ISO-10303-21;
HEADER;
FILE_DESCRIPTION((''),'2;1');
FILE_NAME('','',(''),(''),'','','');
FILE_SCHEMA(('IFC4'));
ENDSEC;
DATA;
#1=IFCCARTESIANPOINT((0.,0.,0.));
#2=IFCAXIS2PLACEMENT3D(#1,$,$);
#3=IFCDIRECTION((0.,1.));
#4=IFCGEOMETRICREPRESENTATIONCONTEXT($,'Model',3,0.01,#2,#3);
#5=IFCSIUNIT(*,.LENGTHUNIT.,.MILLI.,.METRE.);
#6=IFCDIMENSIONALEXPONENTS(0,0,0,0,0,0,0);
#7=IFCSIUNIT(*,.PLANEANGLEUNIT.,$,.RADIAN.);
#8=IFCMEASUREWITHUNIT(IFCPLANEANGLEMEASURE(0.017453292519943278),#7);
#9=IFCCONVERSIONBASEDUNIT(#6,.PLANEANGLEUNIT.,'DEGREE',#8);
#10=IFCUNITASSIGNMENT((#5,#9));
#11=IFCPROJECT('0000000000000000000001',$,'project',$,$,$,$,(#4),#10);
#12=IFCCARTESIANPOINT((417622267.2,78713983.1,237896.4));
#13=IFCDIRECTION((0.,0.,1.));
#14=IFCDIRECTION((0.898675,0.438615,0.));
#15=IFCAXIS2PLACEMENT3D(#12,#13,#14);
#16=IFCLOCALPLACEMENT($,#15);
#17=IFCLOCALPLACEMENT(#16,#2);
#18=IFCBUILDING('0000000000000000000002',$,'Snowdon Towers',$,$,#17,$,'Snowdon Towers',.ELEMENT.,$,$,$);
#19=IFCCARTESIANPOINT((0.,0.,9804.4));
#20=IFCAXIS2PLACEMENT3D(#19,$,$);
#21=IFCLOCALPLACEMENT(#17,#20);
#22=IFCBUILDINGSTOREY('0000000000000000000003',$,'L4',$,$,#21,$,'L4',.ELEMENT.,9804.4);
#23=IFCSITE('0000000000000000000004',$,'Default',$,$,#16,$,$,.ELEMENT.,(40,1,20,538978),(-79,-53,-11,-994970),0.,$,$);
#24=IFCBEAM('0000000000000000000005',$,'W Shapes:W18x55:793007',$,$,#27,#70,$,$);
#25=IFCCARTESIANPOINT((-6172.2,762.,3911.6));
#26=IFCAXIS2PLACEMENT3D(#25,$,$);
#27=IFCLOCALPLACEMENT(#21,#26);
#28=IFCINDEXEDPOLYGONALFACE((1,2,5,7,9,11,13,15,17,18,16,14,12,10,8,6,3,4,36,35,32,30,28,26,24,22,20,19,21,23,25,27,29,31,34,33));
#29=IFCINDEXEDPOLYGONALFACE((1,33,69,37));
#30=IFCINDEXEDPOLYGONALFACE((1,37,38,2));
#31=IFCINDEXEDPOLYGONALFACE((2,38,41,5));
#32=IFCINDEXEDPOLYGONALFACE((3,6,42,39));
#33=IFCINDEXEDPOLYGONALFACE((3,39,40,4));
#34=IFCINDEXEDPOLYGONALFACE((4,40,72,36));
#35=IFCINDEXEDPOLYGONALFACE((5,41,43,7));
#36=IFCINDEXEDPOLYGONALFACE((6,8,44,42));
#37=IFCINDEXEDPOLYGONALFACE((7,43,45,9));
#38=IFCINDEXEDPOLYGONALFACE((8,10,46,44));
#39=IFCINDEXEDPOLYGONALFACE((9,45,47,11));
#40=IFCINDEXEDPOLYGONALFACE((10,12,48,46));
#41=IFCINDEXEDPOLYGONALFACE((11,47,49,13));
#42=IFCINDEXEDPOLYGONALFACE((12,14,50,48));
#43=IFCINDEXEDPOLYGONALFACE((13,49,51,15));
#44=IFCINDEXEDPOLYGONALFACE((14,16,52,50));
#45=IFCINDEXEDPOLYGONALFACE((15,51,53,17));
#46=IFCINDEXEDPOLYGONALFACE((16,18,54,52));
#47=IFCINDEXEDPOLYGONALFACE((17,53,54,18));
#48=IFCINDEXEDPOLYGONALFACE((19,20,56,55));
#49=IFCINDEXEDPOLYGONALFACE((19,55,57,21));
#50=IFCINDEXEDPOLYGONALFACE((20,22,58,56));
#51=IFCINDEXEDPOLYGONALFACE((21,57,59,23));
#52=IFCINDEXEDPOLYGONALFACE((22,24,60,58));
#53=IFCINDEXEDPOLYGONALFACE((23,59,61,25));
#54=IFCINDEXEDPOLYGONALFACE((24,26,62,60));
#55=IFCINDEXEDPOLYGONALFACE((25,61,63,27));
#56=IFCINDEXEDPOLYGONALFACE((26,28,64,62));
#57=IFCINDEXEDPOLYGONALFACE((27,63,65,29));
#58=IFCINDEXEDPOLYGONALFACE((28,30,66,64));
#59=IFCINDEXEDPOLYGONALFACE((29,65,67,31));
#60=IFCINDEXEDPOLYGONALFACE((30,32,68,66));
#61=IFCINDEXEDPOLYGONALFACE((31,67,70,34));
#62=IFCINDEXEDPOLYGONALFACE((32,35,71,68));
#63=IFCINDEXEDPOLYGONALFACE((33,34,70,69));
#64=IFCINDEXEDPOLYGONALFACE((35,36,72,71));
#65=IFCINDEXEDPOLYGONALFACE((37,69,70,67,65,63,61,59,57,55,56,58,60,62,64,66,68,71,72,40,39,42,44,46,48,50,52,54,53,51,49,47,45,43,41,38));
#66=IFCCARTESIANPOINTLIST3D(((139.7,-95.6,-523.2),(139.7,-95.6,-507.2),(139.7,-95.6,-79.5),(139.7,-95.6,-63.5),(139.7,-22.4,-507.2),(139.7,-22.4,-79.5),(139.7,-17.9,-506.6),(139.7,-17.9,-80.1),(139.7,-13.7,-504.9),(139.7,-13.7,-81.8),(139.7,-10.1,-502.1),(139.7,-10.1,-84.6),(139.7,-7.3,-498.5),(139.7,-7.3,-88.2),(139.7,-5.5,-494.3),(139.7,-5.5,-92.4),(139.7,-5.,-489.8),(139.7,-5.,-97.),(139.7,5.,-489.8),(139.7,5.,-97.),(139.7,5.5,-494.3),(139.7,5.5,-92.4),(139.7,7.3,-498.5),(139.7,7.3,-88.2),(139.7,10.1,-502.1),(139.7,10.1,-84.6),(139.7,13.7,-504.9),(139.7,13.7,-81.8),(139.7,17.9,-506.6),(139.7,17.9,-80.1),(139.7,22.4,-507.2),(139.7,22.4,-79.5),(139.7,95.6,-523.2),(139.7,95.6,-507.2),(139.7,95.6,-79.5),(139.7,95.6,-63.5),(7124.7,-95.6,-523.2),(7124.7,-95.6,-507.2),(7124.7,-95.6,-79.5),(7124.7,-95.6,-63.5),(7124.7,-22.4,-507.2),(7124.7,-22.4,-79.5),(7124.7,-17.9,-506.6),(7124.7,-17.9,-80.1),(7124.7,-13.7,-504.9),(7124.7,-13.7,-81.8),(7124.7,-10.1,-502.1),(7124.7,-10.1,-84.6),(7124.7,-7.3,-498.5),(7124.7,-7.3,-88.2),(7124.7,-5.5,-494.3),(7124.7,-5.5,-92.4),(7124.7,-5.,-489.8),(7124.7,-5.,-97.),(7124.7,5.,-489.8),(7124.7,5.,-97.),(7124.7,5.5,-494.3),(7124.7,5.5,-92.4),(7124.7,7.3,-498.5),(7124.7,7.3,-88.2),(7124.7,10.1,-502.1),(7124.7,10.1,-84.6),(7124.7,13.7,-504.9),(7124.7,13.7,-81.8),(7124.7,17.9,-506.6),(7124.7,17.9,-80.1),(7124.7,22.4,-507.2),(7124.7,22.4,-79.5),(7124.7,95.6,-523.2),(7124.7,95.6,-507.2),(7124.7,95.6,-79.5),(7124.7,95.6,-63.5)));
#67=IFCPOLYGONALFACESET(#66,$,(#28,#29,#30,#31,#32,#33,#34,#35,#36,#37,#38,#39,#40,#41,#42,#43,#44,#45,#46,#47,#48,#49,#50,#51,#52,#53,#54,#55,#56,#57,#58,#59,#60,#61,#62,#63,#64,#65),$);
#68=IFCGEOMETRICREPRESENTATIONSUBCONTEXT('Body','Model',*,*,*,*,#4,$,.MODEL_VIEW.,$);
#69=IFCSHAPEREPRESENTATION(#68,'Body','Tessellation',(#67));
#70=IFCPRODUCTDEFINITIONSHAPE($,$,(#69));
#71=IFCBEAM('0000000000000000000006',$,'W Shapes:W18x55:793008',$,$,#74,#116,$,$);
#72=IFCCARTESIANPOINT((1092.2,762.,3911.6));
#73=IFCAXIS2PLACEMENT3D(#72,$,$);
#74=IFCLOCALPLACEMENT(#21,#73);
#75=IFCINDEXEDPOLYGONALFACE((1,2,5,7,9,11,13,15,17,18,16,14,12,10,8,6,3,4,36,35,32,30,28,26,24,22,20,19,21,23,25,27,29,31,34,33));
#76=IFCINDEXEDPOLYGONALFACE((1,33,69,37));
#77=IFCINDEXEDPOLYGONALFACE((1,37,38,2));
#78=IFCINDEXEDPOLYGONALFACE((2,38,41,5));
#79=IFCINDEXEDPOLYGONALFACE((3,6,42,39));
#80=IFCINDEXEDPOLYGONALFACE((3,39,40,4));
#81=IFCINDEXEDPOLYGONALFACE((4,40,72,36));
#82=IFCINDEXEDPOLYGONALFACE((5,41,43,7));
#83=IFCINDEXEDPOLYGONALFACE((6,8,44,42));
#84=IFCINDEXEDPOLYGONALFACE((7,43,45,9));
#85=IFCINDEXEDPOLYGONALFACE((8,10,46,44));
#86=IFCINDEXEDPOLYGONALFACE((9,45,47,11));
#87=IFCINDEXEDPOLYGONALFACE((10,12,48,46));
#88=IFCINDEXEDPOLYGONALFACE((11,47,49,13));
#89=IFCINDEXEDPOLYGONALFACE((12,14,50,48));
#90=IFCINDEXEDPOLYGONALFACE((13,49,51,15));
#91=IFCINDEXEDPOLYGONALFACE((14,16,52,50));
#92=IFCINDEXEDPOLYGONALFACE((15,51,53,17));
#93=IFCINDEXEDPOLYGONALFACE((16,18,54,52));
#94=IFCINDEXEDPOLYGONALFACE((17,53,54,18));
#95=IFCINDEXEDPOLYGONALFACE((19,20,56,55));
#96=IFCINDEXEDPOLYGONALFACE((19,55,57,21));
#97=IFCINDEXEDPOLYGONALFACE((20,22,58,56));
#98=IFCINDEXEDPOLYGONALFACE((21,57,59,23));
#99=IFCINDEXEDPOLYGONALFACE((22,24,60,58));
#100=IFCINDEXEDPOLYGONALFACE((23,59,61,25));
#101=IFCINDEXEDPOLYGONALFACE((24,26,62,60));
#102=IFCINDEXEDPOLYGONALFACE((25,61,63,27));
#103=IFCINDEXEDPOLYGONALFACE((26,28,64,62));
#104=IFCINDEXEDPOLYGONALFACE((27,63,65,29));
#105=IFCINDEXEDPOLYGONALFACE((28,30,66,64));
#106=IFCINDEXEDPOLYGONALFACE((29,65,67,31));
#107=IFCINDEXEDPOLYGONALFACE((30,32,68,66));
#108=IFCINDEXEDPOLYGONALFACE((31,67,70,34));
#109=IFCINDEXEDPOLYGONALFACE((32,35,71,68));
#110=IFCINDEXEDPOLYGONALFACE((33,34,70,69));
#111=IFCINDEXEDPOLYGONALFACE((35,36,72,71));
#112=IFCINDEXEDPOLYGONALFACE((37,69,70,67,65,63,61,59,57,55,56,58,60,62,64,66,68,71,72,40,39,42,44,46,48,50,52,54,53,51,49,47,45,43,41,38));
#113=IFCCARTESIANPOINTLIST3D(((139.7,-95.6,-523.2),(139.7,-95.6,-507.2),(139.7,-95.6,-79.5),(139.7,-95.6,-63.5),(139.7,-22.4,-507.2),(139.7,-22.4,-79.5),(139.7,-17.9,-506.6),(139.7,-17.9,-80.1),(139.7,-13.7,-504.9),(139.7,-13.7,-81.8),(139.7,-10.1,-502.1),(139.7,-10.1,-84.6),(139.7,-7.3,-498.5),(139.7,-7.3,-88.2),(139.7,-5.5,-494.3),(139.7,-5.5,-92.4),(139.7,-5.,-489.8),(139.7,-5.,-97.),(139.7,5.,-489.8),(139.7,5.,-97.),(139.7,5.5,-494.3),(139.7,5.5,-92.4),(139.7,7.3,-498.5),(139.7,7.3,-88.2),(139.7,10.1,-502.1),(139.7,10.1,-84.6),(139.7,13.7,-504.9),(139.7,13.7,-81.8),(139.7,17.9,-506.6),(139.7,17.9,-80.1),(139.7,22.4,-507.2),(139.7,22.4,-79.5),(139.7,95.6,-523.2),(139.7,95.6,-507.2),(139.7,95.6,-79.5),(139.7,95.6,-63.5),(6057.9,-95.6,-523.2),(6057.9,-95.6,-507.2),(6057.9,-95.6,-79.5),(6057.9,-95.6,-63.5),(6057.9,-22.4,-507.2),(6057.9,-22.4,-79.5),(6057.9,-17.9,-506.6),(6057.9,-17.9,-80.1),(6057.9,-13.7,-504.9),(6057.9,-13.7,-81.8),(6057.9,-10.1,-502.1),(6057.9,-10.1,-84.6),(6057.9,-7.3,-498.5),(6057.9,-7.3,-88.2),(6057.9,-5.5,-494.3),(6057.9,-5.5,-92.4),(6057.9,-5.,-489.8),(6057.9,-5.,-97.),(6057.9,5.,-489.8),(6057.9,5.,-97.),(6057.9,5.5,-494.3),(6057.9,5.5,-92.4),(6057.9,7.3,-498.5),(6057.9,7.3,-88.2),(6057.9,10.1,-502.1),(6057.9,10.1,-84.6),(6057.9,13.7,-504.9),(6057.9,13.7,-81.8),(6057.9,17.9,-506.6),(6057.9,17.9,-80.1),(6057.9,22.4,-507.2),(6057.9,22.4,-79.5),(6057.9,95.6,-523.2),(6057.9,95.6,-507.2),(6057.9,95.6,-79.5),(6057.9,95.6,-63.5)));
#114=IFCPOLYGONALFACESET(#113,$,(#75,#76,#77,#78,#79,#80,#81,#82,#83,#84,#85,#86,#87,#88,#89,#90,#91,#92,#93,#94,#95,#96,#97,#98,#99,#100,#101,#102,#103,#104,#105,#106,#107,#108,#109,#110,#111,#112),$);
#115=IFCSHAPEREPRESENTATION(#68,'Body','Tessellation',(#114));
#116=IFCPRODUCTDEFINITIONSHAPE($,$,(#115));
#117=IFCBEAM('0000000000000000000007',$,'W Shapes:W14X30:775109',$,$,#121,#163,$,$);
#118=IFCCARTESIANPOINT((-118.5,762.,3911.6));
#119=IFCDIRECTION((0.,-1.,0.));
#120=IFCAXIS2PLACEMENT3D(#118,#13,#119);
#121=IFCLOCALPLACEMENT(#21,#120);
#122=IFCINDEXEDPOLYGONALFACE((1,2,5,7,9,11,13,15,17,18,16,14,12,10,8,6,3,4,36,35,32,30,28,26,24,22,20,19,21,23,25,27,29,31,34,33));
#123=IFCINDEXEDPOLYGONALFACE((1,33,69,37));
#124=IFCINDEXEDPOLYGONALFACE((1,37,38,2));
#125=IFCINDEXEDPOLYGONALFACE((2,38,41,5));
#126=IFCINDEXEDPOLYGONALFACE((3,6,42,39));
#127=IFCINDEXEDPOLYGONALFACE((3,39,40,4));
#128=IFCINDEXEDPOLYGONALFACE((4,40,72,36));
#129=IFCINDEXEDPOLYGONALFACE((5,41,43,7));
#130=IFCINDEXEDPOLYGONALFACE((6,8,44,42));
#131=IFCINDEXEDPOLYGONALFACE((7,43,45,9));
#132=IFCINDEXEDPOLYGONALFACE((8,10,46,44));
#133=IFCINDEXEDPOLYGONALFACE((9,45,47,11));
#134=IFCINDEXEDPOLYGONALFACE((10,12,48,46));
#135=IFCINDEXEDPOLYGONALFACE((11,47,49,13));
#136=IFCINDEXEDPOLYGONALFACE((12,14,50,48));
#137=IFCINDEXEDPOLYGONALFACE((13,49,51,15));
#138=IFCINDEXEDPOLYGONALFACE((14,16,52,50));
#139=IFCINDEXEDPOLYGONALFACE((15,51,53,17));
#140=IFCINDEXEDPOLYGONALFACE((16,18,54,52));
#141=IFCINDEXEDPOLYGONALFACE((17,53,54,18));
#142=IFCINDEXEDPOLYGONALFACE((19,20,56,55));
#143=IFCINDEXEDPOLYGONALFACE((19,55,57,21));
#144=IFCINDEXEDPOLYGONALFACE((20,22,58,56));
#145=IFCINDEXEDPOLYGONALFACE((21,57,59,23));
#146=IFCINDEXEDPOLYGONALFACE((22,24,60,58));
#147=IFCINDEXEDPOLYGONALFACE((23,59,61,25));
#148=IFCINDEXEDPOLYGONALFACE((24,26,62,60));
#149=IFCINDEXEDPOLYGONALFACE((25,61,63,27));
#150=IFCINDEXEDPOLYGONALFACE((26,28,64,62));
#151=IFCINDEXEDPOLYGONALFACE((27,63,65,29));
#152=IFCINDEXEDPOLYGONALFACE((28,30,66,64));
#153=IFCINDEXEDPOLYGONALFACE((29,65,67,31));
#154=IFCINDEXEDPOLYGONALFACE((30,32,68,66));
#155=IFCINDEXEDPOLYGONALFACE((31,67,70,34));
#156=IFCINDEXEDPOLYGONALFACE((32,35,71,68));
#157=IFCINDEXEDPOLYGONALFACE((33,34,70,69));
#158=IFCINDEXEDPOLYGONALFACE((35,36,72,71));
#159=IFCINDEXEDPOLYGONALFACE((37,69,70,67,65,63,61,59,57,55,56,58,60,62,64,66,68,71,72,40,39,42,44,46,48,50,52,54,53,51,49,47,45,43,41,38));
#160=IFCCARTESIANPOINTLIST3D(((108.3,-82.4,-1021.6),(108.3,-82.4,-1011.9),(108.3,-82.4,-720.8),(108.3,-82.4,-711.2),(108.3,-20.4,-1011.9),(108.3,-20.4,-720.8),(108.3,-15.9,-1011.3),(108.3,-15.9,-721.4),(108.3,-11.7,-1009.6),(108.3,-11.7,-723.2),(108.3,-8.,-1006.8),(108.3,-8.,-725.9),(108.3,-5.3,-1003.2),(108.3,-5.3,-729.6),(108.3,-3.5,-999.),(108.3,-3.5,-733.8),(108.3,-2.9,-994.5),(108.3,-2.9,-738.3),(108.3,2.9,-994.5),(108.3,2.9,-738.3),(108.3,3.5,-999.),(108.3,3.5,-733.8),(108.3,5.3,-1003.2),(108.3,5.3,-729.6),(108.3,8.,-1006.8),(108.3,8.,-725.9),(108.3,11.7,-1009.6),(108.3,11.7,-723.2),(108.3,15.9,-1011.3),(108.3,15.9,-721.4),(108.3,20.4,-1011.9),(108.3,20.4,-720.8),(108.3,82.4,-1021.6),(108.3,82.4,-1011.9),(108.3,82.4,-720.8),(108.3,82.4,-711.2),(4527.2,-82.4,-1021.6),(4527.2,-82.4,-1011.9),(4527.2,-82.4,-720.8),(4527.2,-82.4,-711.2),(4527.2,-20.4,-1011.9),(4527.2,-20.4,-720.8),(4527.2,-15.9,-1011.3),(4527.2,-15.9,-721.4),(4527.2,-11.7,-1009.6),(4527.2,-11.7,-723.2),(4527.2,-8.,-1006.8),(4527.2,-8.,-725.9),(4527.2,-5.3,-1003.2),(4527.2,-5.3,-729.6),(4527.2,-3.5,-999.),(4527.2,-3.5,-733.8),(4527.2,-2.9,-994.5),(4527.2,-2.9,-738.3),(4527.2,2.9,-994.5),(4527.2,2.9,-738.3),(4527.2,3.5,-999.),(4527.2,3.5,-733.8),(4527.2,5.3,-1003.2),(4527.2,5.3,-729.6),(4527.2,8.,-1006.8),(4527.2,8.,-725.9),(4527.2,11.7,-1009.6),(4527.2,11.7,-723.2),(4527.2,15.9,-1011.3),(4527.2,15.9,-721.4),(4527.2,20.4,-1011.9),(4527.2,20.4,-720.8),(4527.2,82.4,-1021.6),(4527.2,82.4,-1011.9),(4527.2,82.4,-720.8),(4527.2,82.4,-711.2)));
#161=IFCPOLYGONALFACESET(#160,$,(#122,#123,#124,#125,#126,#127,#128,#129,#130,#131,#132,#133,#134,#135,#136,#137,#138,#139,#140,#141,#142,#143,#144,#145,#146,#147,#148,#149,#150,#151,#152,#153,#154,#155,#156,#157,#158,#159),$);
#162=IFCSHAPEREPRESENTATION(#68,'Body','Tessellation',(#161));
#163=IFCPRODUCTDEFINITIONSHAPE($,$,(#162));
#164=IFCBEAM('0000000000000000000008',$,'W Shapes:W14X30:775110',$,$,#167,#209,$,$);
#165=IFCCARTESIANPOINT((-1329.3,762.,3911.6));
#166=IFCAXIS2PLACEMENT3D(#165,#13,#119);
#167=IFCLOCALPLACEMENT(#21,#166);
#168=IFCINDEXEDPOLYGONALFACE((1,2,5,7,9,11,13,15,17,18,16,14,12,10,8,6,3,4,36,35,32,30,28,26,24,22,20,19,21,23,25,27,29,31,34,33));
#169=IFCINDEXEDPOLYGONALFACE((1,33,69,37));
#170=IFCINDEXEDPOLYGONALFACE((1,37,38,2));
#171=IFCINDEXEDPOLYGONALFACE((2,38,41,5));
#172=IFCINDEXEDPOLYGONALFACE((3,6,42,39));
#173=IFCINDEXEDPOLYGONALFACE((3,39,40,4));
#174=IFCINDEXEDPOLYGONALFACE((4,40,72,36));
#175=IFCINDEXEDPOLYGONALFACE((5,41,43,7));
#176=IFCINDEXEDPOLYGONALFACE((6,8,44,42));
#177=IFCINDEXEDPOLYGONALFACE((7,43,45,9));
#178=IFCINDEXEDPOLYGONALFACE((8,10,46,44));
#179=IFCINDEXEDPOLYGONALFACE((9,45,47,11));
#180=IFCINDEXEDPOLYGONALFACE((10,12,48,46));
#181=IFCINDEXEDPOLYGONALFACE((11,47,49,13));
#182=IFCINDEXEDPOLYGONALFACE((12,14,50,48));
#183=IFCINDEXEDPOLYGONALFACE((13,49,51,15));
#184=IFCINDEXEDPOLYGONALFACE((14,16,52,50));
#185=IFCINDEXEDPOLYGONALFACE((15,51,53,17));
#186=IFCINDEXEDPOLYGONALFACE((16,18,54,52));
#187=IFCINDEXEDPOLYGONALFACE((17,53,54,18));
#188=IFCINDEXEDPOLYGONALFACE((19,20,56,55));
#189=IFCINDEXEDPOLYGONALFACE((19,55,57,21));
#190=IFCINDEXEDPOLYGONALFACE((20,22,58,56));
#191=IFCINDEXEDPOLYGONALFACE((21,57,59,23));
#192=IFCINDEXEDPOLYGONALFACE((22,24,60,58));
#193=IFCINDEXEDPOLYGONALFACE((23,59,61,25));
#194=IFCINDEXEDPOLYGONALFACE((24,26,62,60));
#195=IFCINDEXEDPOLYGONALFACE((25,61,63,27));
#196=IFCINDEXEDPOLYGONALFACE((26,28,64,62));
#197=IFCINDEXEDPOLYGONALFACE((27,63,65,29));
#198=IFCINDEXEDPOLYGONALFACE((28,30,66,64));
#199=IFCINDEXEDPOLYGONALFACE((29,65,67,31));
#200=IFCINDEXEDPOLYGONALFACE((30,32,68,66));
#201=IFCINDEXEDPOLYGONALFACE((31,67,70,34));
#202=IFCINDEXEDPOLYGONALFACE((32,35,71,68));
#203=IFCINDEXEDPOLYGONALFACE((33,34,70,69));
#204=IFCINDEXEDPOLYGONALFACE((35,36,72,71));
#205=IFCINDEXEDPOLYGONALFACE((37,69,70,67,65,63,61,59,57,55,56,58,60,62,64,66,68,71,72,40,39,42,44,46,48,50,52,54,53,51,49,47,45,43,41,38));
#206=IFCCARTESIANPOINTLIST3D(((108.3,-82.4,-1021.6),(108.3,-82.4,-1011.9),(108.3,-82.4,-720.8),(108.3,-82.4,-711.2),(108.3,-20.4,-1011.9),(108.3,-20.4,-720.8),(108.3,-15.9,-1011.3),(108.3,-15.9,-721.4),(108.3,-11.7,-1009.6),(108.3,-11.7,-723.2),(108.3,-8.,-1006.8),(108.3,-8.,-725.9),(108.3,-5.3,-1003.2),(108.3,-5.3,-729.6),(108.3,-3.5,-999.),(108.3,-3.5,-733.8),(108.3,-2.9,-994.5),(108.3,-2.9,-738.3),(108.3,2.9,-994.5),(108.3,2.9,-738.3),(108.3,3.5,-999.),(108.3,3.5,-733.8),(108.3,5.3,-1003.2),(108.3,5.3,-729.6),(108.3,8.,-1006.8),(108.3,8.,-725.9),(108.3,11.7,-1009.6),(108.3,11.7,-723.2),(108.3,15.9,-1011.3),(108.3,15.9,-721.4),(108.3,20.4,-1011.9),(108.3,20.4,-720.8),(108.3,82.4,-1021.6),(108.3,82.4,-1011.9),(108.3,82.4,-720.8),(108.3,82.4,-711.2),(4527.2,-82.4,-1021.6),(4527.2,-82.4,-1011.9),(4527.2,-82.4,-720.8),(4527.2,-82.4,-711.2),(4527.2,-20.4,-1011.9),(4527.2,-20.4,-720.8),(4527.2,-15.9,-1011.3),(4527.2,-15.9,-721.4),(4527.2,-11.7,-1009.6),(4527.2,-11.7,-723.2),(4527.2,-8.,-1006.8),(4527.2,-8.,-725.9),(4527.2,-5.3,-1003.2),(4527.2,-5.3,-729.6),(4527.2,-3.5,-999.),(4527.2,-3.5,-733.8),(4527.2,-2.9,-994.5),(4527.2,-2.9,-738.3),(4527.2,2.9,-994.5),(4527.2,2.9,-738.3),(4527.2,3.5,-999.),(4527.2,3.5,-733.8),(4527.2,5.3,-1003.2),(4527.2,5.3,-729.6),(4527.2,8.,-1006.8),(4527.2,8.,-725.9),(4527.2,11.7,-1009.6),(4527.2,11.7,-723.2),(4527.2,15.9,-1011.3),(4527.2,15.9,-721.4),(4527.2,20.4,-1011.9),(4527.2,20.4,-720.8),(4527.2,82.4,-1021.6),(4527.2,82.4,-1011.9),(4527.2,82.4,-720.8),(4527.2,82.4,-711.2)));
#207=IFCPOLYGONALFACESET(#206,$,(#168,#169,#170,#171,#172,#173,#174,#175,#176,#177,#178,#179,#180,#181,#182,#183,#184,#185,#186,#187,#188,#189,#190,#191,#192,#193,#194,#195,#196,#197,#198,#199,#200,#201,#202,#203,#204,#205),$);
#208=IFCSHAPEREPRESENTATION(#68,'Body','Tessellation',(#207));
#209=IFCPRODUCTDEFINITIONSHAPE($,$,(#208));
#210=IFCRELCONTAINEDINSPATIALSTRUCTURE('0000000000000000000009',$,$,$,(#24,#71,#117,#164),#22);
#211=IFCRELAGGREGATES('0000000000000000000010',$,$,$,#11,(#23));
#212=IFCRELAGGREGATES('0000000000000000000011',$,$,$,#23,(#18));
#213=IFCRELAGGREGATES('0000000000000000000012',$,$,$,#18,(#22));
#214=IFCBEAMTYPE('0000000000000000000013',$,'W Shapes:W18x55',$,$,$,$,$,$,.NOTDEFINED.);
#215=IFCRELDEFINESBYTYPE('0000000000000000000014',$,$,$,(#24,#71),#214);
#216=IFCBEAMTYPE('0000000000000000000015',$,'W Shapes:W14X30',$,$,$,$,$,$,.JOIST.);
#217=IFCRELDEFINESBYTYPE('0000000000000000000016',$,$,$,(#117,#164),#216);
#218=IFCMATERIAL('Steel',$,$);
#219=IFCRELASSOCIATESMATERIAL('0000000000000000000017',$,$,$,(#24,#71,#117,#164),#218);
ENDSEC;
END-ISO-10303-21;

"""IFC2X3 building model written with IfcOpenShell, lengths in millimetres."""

from ifc_helpers import new_model, entity, si_unit, converted_unit, direction, frame, frame_2d, origin, place, context, subcontext, project, spatial, i_section, extrude, material, type_object, element, save


model = new_model("IFC2X3")

# Units and contexts
model_context = context("Model", 3, precision=0.01, world=origin(), true_north=direction((0.0, 1.0)))
body_context = subcontext(model_context, "Body", "Model", "MODEL_VIEW")
ifc_project = project(units=[si_unit("LENGTHUNIT", "METRE", prefix="MILLI"), converted_unit("PLANEANGLEUNIT", "DEGREE", entity("IfcPlaneAngleMeasure", 0.017453292519943278), si_unit("PLANEANGLEUNIT", "RADIAN"), dimensions=[0, 0, 0, 0, 0, 0, 0])], contexts=[model_context])

# Site, building, storey
site_placement = place(None, frame((417622267.2, 78713983.1, 237896.4), z_axis=(0.0, 0.0, 1.0), x_axis=(0.898675, 0.438615, 0.0)))
site = spatial("IfcSite", under=ifc_project, at=site_placement, Name="Default", CompositionType="ELEMENT", RefLatitude=(40, 1, 20, 538978), RefLongitude=(-79, -53, -11, -994970), RefElevation=0.0)
building_placement = place(site_placement, origin())
building = spatial("IfcBuilding", under=site, at=building_placement, Name="Snowdon Towers", LongName="Snowdon Towers", CompositionType="ELEMENT")
storey_placement = place(building_placement, frame((0.0, 0.0, 9804.4)))
storey = spatial("IfcBuildingStorey", under=building, at=storey_placement, Name="L4", LongName="L4", CompositionType="ELEMENT", Elevation=9804.4)

# Shared definitions
ifc_material_1 = material(Name="Steel")

# Beams
beam_type_1 = type_object("IfcBeamType", Name="W Shapes:W18x55", PredefinedType="NOTDEFINED")
beam_1_placement = place(storey_placement, frame((-6172.2, 762.0, 3911.6)))
element("IfcBeam", 1, at=beam_1_placement, inside=storey, type_object=beam_type_1, material=ifc_material_1, Name="W Shapes:W18x55:793007", context=body_context, shape_type="SweptSolid", body=[
    extrude(i_section(OverallWidth=191.3, OverallDepth=459.7, WebThickness=9.9, FlangeThickness=16.0, FilletRadius=17.5, at=frame_2d((0.0, 0.0), x_axis=(0.0, 1.0))), frame((139.7, 0.0, -293.4), z_axis=(1.0, 0.0, 0.0), x_axis=(0.0, 0.0, -1.0)), (0.0, 0.0, 1.0), 6985.0),
])
beam_2_placement = place(storey_placement, frame((1092.2, 762.0, 3911.6)))
element("IfcBeam", 2, at=beam_2_placement, inside=storey, type_object=beam_type_1, material=ifc_material_1, Name="W Shapes:W18x55:793008", context=body_context, shape_type="SweptSolid", body=[
    extrude(i_section(OverallWidth=191.3, OverallDepth=459.7, WebThickness=9.9, FlangeThickness=16.0, FilletRadius=17.5, at=frame_2d((0.0, 0.0), x_axis=(0.0, 1.0))), frame((139.7, 0.0, -293.4), z_axis=(1.0, 0.0, 0.0), x_axis=(0.0, 0.0, -1.0)), (0.0, 0.0, 1.0), 5918.2),
])
beam_type_2 = type_object("IfcBeamType", Name="W Shapes:W14X30", PredefinedType="JOIST")
beam_3_placement = place(storey_placement, frame((-118.5, 762.0, 3911.6), z_axis=(0.0, 0.0, 1.0), x_axis=(0.0, -1.0, 0.0)))
element("IfcBeam", 3, at=beam_3_placement, inside=storey, type_object=beam_type_2, material=ifc_material_1, Name="W Shapes:W14X30:775109", context=body_context, shape_type="SweptSolid", body=[
    extrude(i_section(OverallWidth=164.8, OverallDepth=310.4, WebThickness=5.9, FlangeThickness=9.6, FilletRadius=17.5, at=frame_2d((0.0, 0.0), x_axis=(0.0, 1.0))), frame((108.3, 0.0, -866.4), z_axis=(1.0, 0.0, 0.0), x_axis=(0.0, 0.0, -1.0)), (0.0, 0.0, 1.0), 4418.8),
])
beam_4_placement = place(storey_placement, frame((-1329.3, 762.0, 3911.6), z_axis=(0.0, 0.0, 1.0), x_axis=(0.0, -1.0, 0.0)))
element("IfcBeam", 4, at=beam_4_placement, inside=storey, type_object=beam_type_2, material=ifc_material_1, Name="W Shapes:W14X30:775110", context=body_context, shape_type="SweptSolid", body=[
    extrude(i_section(OverallWidth=164.8, OverallDepth=310.4, WebThickness=5.9, FlangeThickness=9.6, FilletRadius=17.5, at=frame_2d((0.0, 0.0), x_axis=(0.0, 1.0))), frame((108.3, 0.0, -866.4), z_axis=(1.0, 0.0, 0.0), x_axis=(0.0, 0.0, -1.0)), (0.0, 0.0, 1.0), 4418.8),
])

save(model, "model.ifc")
